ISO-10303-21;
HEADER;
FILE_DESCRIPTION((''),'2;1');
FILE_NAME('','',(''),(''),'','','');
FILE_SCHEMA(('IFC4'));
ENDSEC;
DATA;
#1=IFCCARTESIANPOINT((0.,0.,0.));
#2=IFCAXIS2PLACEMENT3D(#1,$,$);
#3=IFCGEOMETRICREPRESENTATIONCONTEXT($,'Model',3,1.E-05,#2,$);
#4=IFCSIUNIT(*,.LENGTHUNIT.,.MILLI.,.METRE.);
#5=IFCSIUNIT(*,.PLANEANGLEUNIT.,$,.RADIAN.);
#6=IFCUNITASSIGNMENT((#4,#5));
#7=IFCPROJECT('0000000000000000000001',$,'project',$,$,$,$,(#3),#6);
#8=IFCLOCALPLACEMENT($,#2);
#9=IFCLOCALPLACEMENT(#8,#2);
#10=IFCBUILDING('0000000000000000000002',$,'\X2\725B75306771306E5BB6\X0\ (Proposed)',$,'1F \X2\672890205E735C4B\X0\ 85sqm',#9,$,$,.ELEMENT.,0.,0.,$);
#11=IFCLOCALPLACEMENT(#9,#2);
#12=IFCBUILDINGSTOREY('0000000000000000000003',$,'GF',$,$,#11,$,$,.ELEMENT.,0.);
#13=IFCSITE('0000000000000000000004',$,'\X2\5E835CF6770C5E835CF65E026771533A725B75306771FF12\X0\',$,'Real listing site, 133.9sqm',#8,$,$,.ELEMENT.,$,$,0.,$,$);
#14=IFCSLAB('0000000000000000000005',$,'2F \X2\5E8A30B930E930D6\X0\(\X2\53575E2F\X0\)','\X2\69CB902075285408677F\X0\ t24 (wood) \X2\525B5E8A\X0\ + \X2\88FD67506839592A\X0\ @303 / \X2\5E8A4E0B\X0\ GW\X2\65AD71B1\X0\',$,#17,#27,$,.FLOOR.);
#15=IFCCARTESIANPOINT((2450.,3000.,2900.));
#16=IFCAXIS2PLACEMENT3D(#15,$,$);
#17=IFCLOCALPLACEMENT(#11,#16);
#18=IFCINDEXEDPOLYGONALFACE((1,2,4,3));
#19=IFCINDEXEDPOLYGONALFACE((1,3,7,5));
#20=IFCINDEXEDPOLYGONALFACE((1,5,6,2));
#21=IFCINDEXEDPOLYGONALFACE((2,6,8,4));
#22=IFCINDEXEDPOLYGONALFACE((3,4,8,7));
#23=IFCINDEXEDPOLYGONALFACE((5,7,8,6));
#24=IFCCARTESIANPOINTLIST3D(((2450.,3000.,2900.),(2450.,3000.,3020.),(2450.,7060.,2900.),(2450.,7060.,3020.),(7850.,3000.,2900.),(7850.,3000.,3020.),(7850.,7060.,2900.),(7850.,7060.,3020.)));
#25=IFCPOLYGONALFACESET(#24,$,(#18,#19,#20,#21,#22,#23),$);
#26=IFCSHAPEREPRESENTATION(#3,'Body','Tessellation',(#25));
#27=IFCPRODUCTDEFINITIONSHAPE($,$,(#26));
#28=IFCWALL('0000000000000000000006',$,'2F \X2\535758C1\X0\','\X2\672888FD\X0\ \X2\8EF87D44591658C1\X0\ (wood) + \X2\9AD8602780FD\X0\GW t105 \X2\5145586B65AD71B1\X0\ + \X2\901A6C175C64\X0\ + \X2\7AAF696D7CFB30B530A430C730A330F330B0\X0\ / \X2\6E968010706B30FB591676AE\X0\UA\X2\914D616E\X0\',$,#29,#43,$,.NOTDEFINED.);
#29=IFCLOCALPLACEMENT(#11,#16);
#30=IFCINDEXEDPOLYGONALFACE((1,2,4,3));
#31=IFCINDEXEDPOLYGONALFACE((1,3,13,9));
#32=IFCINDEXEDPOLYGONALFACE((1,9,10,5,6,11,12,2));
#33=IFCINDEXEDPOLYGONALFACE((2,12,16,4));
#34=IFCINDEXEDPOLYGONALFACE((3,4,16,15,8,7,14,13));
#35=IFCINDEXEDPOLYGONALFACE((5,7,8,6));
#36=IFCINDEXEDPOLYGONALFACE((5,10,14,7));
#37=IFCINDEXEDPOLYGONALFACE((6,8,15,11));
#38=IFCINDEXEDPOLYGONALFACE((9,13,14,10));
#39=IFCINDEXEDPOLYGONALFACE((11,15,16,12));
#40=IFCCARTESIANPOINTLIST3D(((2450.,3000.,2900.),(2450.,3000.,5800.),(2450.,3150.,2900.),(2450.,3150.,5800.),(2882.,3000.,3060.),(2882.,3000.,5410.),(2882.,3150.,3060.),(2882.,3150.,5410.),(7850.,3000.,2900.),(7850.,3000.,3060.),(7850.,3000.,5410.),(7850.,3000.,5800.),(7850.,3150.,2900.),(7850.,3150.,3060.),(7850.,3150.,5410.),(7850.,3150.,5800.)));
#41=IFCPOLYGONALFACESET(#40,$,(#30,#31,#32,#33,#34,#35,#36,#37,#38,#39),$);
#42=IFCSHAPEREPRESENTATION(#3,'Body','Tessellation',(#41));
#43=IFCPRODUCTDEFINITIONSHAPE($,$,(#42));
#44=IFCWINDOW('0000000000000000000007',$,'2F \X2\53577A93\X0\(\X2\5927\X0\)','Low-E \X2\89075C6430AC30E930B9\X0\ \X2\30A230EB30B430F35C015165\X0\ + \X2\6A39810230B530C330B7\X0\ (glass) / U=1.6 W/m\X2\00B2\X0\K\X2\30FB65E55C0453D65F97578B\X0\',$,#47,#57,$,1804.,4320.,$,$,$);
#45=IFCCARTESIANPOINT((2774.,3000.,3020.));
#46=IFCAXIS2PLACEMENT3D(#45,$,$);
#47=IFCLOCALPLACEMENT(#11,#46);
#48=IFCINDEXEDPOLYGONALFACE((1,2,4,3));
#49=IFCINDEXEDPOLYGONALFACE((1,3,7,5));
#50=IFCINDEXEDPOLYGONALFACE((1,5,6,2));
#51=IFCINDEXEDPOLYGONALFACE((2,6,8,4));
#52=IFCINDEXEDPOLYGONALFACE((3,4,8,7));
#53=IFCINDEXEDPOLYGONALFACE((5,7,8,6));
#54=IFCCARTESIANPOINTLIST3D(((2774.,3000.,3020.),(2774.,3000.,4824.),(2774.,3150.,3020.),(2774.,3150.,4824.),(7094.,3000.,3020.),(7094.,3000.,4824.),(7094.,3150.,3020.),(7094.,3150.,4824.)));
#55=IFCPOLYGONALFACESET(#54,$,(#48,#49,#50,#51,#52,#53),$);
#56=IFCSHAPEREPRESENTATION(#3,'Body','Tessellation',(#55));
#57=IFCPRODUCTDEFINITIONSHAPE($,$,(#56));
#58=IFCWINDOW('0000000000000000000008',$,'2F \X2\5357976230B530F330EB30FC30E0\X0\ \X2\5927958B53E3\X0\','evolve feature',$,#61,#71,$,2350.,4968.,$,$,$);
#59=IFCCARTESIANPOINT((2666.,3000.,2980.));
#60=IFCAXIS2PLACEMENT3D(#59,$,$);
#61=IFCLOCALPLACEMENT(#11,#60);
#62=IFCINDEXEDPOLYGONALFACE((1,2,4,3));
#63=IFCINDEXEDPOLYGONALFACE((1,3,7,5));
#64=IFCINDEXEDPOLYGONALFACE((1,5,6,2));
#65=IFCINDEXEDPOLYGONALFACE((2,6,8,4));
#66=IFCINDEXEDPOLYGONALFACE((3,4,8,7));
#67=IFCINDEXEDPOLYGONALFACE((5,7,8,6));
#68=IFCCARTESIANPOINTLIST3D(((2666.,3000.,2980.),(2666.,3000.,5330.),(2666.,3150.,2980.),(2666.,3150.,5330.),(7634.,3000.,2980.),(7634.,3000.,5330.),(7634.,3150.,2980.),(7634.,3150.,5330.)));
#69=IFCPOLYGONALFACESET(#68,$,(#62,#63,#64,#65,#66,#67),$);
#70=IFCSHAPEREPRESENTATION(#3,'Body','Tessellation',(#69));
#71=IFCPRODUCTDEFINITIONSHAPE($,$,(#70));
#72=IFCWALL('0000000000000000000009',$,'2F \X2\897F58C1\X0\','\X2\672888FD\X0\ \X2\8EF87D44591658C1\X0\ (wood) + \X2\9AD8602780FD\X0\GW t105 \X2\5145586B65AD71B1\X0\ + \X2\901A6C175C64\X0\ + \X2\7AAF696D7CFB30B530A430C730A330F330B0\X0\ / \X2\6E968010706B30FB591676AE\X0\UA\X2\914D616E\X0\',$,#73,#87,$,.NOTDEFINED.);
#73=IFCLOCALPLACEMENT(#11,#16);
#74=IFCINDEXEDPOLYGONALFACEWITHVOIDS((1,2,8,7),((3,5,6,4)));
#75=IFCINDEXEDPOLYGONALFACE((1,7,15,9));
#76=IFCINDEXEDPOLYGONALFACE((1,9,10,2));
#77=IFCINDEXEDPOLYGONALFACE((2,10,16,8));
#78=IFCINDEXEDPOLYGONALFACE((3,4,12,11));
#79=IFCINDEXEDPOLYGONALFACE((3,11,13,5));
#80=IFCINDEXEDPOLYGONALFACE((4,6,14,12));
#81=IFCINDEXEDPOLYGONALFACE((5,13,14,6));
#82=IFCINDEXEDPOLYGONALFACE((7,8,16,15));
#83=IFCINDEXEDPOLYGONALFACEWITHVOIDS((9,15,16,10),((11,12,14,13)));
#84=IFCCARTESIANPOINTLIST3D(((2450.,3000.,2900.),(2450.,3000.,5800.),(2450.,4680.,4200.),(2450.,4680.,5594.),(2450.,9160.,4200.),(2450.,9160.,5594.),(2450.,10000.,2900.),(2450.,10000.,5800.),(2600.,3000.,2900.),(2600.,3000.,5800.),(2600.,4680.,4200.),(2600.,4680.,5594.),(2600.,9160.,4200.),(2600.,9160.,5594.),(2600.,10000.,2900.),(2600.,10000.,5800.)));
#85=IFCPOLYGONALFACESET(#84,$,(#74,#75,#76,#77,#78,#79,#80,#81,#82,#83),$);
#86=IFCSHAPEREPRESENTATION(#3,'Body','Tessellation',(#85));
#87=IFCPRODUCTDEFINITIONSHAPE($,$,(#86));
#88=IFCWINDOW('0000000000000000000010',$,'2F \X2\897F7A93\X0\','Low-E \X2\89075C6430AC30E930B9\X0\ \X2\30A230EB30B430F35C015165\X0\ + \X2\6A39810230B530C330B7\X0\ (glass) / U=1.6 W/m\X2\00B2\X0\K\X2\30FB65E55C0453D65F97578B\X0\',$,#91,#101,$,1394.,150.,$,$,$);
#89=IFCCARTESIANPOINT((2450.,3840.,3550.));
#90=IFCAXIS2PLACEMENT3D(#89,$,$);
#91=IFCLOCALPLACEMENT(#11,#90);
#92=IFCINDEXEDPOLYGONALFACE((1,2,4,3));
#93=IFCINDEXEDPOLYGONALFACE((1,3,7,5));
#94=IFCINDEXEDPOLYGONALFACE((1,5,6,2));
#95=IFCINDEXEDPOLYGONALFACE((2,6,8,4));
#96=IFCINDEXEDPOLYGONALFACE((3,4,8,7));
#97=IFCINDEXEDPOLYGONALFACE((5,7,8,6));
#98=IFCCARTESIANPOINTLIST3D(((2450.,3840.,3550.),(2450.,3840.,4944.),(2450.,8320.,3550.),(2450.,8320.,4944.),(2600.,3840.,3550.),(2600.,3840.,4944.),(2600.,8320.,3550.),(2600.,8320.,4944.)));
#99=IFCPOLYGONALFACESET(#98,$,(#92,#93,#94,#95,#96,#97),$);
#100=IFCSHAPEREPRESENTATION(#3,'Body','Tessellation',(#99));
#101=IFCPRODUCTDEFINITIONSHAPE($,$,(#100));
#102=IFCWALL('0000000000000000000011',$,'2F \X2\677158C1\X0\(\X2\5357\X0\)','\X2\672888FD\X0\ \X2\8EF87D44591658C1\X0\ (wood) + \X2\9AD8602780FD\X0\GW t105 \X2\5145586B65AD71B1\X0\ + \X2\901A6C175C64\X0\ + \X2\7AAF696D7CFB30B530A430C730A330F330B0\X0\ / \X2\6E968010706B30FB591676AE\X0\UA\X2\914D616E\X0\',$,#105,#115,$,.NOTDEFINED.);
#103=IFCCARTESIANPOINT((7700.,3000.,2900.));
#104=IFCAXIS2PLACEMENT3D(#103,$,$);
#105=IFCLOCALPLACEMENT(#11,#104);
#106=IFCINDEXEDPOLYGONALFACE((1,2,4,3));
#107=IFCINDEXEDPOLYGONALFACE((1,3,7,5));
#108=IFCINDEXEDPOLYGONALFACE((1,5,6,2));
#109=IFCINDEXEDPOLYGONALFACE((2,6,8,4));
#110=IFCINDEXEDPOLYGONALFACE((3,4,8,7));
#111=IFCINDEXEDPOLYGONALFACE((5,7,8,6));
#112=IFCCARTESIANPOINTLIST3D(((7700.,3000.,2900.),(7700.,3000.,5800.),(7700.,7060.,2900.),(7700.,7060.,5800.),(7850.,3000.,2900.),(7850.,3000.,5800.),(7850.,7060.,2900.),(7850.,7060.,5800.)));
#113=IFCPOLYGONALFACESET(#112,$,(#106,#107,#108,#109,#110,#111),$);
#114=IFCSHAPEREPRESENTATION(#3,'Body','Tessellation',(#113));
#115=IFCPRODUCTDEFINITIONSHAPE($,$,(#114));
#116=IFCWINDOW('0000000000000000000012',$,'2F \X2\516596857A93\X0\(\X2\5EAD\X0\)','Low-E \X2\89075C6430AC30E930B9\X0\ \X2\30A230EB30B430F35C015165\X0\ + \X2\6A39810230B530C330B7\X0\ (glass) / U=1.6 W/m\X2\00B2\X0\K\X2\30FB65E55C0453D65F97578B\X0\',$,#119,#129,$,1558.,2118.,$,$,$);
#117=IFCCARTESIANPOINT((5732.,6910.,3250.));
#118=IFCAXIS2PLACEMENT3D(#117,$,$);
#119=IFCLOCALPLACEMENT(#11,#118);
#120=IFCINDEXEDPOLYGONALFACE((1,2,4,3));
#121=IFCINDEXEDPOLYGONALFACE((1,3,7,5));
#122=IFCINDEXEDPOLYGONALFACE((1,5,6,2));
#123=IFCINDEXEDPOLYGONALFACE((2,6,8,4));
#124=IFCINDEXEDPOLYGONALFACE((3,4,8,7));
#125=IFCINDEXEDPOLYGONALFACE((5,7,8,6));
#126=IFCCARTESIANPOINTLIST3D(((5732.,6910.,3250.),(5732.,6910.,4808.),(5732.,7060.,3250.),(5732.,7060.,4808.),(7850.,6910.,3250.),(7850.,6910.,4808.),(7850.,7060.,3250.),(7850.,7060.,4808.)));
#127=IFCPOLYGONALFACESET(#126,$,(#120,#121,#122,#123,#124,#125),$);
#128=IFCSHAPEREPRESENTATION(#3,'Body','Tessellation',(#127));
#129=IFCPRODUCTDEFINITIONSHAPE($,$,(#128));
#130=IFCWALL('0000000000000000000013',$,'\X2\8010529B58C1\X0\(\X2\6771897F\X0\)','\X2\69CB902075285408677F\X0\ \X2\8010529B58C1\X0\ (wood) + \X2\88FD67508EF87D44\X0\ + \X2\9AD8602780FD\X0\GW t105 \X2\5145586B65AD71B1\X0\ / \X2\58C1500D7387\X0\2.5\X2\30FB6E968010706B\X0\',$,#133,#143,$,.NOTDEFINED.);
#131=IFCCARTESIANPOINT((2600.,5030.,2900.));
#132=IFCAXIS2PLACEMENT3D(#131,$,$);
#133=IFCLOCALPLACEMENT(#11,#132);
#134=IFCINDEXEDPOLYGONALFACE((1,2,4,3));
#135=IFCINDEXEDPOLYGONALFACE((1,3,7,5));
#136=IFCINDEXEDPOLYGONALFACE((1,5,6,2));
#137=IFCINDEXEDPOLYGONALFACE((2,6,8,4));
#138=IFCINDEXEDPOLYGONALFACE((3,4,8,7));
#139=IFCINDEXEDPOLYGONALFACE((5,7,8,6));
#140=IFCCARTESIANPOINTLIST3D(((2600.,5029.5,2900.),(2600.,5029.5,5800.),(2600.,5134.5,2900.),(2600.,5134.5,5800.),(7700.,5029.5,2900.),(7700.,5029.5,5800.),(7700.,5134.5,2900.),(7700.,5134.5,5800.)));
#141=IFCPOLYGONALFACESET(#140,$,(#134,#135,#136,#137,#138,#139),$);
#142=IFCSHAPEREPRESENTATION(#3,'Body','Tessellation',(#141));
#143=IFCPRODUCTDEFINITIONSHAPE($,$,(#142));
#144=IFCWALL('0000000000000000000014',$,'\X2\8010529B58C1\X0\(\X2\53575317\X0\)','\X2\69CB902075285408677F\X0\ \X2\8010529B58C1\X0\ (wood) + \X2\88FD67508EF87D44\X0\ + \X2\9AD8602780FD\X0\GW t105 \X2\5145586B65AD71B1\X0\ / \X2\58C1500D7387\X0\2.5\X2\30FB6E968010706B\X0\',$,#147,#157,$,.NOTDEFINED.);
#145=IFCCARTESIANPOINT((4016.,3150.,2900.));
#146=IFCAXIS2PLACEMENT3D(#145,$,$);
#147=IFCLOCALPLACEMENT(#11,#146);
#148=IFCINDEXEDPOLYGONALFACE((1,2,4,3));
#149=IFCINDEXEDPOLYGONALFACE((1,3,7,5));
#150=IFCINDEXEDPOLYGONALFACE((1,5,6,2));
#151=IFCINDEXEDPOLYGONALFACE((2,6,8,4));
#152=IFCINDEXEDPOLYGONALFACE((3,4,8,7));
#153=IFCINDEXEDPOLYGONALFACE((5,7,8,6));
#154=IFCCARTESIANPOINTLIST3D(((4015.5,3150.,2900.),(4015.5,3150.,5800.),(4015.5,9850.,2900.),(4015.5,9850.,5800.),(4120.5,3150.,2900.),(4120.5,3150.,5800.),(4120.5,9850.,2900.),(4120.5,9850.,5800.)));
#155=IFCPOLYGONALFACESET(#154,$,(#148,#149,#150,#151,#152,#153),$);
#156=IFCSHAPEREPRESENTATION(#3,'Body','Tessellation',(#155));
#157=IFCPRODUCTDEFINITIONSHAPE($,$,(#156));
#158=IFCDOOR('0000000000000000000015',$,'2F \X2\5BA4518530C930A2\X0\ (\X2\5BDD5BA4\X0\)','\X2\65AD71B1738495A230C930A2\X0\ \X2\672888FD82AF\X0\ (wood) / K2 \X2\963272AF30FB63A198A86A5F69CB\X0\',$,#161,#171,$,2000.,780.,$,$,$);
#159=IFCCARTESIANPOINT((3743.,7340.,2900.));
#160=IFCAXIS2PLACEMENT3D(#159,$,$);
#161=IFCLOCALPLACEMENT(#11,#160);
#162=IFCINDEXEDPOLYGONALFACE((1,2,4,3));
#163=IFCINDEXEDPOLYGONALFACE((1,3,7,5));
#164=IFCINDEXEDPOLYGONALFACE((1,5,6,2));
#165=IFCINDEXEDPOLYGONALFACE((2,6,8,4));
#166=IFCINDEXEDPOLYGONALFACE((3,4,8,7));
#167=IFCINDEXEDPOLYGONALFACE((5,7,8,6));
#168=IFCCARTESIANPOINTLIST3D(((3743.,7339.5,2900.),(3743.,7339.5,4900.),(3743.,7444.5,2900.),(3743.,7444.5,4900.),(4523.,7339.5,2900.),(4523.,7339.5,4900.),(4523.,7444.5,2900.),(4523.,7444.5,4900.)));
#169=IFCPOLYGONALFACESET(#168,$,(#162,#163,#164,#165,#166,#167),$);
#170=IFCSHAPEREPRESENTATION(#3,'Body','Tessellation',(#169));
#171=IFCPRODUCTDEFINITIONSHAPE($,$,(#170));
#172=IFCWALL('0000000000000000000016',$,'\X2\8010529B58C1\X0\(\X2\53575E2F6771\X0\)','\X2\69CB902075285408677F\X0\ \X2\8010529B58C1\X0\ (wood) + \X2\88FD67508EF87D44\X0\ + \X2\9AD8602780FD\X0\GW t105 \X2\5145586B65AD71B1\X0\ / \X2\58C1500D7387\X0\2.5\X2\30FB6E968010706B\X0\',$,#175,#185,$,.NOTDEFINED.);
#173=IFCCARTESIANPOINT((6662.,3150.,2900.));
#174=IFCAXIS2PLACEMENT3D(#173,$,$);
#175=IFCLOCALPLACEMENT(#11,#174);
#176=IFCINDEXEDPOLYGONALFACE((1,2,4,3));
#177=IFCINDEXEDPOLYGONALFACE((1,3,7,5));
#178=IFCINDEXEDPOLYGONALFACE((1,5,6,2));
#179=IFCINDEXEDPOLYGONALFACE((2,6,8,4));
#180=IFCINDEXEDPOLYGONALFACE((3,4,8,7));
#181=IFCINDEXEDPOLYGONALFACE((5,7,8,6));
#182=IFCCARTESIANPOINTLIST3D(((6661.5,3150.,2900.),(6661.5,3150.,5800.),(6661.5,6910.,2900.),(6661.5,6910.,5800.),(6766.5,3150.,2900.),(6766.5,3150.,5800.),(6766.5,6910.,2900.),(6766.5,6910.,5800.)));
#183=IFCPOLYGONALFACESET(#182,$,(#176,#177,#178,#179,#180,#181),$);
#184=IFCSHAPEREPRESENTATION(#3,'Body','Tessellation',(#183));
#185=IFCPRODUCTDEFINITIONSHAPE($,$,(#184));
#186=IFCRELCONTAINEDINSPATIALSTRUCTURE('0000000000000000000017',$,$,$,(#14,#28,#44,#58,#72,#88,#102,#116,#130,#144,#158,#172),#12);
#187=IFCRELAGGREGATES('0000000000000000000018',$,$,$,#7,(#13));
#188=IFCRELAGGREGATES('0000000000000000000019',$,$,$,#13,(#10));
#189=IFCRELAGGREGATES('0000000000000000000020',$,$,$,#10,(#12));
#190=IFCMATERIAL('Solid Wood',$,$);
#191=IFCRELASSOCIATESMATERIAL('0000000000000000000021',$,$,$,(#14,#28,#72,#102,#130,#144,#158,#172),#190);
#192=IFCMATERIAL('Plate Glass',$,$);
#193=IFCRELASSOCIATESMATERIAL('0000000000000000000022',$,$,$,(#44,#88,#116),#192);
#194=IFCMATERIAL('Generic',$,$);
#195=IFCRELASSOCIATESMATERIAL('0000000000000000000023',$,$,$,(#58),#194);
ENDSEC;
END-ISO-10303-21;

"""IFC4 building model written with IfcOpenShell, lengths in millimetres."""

from ifc_helpers import new_model, si_unit, frame, frame_2d, origin, place, context, project, spatial, rectangle, extrude, material, element, fill, save


model = new_model("IFC4")

# Units and contexts
model_context = context("Model", 3, precision=1e-05, world=origin())
ifc_project = project(units=[si_unit("LENGTHUNIT", "METRE", prefix="MILLI"), si_unit("PLANEANGLEUNIT", "RADIAN")], contexts=[model_context])

# Site, building, storey
site_placement = place(None, origin())
site = spatial("IfcSite", under=ifc_project, at=site_placement, Name="広島県広島市東区牛田東２", ObjectType="Real listing site, 133.9sqm", CompositionType="ELEMENT", RefElevation=0.0)
building_placement = place(site_placement, origin())
building = spatial("IfcBuilding", under=site, at=building_placement, Name="牛田東の家 (Proposed)", ObjectType="1F 木造平屋 85sqm", CompositionType="ELEMENT", ElevationOfRefHeight=0.0, ElevationOfTerrain=0.0)
storey_placement = place(building_placement, origin())
storey = spatial("IfcBuildingStorey", under=building, at=storey_placement, Name="GF", CompositionType="ELEMENT", Elevation=0.0)

# Slab
ifc_material_1 = material(Name="Solid Wood")
slab_placement = place(storey_placement, frame((2450.0, 3000.0, 2900.0)))
element("IfcSlab", 1, at=slab_placement, inside=storey, material=ifc_material_1, Name="2F 床スラブ(南帯)", Description="構造用合板 t24 (wood) 剛床 + 製材根太 @303 / 床下 GW断熱", PredefinedType="FLOOR", context=model_context, shape_type="SweptSolid", body=[
    extrude(rectangle(XDim=5400.0, YDim=4060.0, at=frame_2d((2700.0, 2030.0))), frame((2450.0, 3000.0, 2900.0)), (0.0, 0.0, 1.0), 120.0),
])

# Wall, openings, windows
wall_1_placement = place(storey_placement, frame((2450.0, 3000.0, 2900.0)))
wall_1 = element("IfcWall", 2, at=wall_1_placement, inside=storey, material=ifc_material_1, Name="2F 南壁", Description="木製 軸組外壁 (wood) + 高性能GW t105 充填断熱 + 通気層 + 窯業系サイディング / 準耐火・外皮UA配慮", PredefinedType="NOTDEFINED", context=model_context, shape_type="SweptSolid", body=[
    extrude(rectangle(XDim=5400.0, YDim=150.0, at=frame_2d((2700.0, 75.0))), frame((2450.0, 3000.0, 2900.0)), (0.0, 0.0, 1.0), 2900.0),
])
opening_1_placement = place(storey_placement, frame((2774.0, 3000.0, 3020.0)))
opening_1 = element("IfcOpeningElement", 3, at=opening_1_placement, cuts=wall_1, PredefinedType="NOTDEFINED", context=model_context, shape_type="SweptSolid", body=[
    extrude(rectangle(XDim=4320.0, YDim=150.0, at=frame_2d((2160.0, 75.0))), frame((2774.0, 3000.0, 3020.0)), (0.0, 0.0, 1.0), 1804.0),
])
opening_2_placement = place(storey_placement, frame((2666.0, 3000.0, 2980.0)))
opening_2 = element("IfcOpeningElement", 4, at=opening_2_placement, cuts=wall_1, PredefinedType="NOTDEFINED", context=model_context, shape_type="SweptSolid", body=[
    extrude(rectangle(XDim=4968.0, YDim=150.0, at=frame_2d((2484.0, 75.0))), frame((2666.0, 3000.0, 2980.0)), (0.0, 0.0, 1.0), 2350.0),
])
ifc_material_2 = material(Name="Plate Glass")
window_1_placement = place(storey_placement, frame((2774.0, 3000.0, 3020.0)))
window_1 = element("IfcWindow", 5, at=window_1_placement, inside=storey, material=ifc_material_2, Name="2F 南窓(大)", Description="Low-E 複層ガラス アルゴン封入 + 樹脂サッシ (glass) / U=1.6 W/m²K・日射取得型", OverallHeight=1804.0, OverallWidth=4320.0, context=model_context, shape_type="SweptSolid", body=[
    extrude(rectangle(XDim=4320.0, YDim=150.0, at=frame_2d((2160.0, 75.0))), frame((2774.0, 3000.0, 3020.0)), (0.0, 0.0, 1.0), 1804.0),
])
fill(opening_1, window_1)
ifc_material_3 = material(Name="Generic")
window_2_placement = place(storey_placement, frame((2666.0, 3000.0, 2980.0)))
window_2 = element("IfcWindow", 6, at=window_2_placement, inside=storey, material=ifc_material_3, Name="2F 南面サンルーム 大開口", Description="evolve feature", OverallHeight=2350.0, OverallWidth=4968.0, context=model_context, shape_type="SweptSolid", body=[
    extrude(rectangle(XDim=4968.0, YDim=150.0, at=frame_2d((2484.0, 75.0))), frame((2666.0, 3000.0, 2980.0)), (0.0, 0.0, 1.0), 2350.0),
])
fill(opening_2, window_2)

# Walls, openings, windows
wall_2_placement = place(storey_placement, frame((2450.0, 3000.0, 2900.0)))
wall_2 = element("IfcWall", 7, at=wall_2_placement, inside=storey, material=ifc_material_1, Name="2F 西壁", Description="木製 軸組外壁 (wood) + 高性能GW t105 充填断熱 + 通気層 + 窯業系サイディング / 準耐火・外皮UA配慮", PredefinedType="NOTDEFINED", context=model_context, shape_type="SweptSolid", body=[
    extrude(rectangle(XDim=150.0, YDim=7000.0, at=frame_2d((75.0, 3500.0))), frame((2450.0, 3000.0, 2900.0)), (0.0, 0.0, 1.0), 2900.0),
])
opening_3_placement = place(storey_placement, frame((2450.0, 3840.0, 3550.0)))
opening_3 = element("IfcOpeningElement", 8, at=opening_3_placement, cuts=wall_2, PredefinedType="NOTDEFINED", context=model_context, shape_type="SweptSolid", body=[
    extrude(rectangle(XDim=150.0, YDim=4480.0, at=frame_2d((75.0, 2240.0))), frame((2450.0, 3840.0, 3550.0)), (0.0, 0.0, 1.0), 1394.0),
])
window_3_placement = place(storey_placement, frame((2450.0, 3840.0, 3550.0)))
window_3 = element("IfcWindow", 9, at=window_3_placement, inside=storey, material=ifc_material_2, Name="2F 西窓", Description="Low-E 複層ガラス アルゴン封入 + 樹脂サッシ (glass) / U=1.6 W/m²K・日射取得型", OverallHeight=1394.0, OverallWidth=150.0, context=model_context, shape_type="SweptSolid", body=[
    extrude(rectangle(XDim=150.0, YDim=4480.0, at=frame_2d((75.0, 2240.0))), frame((2450.0, 3840.0, 3550.0)), (0.0, 0.0, 1.0), 1394.0),
])
fill(opening_3, window_3)
wall_3_placement = place(storey_placement, frame((7700.0, 3000.0, 2900.0)))
wall_3 = element("IfcWall", 10, at=wall_3_placement, inside=storey, material=ifc_material_1, Name="2F 東壁(南)", Description="木製 軸組外壁 (wood) + 高性能GW t105 充填断熱 + 通気層 + 窯業系サイディング / 準耐火・外皮UA配慮", PredefinedType="NOTDEFINED", context=model_context, shape_type="SweptSolid", body=[
    extrude(rectangle(XDim=150.0, YDim=4060.0, at=frame_2d((75.0, 2030.0))), frame((7700.0, 3000.0, 2900.0)), (0.0, 0.0, 1.0), 2900.0),
])
opening_4_placement = place(storey_placement, frame((5732.0, 6910.0, 3250.0)))
opening_4 = element("IfcOpeningElement", 11, at=opening_4_placement, cuts=wall_3, PredefinedType="NOTDEFINED", context=model_context, shape_type="SweptSolid", body=[
    extrude(rectangle(XDim=2118.0, YDim=150.0, at=frame_2d((1059.0, 75.0))), frame((5732.0, 6910.0, 3250.0)), (0.0, 0.0, 1.0), 1558.0),
])
window_4_placement = place(storey_placement, frame((5732.0, 6910.0, 3250.0)))
window_4 = element("IfcWindow", 12, at=window_4_placement, inside=storey, material=ifc_material_2, Name="2F 入隅窓(庭)", Description="Low-E 複層ガラス アルゴン封入 + 樹脂サッシ (glass) / U=1.6 W/m²K・日射取得型", OverallHeight=1558.0, OverallWidth=2118.0, context=model_context, shape_type="SweptSolid", body=[
    extrude(rectangle(XDim=2118.0, YDim=150.0, at=frame_2d((1059.0, 75.0))), frame((5732.0, 6910.0, 3250.0)), (0.0, 0.0, 1.0), 1558.0),
])
fill(opening_4, window_4)

# Wall
wall_4_placement = place(storey_placement, frame((2600.0, 5030.0, 2900.0)))
element("IfcWall", 13, at=wall_4_placement, inside=storey, material=ifc_material_1, Name="耐力壁(東西)", Description="構造用合板 耐力壁 (wood) + 製材軸組 + 高性能GW t105 充填断熱 / 壁倍率2.5・準耐火", PredefinedType="NOTDEFINED", context=model_context, shape_type="SweptSolid", body=[
    extrude(rectangle(XDim=5100.0, YDim=105.0, at=frame_2d((2550.0, 52.0))), frame((2600.0, 5030.0, 2900.0)), (0.0, 0.0, 1.0), 2900.0),
])

# Wall, opening, door
wall_5_placement = place(storey_placement, frame((4016.0, 3150.0, 2900.0)))
wall_5 = element("IfcWall", 14, at=wall_5_placement, inside=storey, material=ifc_material_1, Name="耐力壁(南北)", Description="構造用合板 耐力壁 (wood) + 製材軸組 + 高性能GW t105 充填断熱 / 壁倍率2.5・準耐火", PredefinedType="NOTDEFINED", context=model_context, shape_type="SweptSolid", body=[
    extrude(rectangle(XDim=105.0, YDim=6700.0, at=frame_2d((52.0, 3350.0))), frame((4016.0, 3150.0, 2900.0)), (0.0, 0.0, 1.0), 2900.0),
])
opening_5_placement = place(storey_placement, frame((3743.0, 7340.0, 2900.0)))
opening_5 = element("IfcOpeningElement", 15, at=opening_5_placement, cuts=wall_5, PredefinedType="NOTDEFINED", context=model_context, shape_type="SweptSolid", body=[
    extrude(rectangle(XDim=780.0, YDim=105.0, at=frame_2d((390.0, 52.0))), frame((3743.0, 7340.0, 2900.0)), (0.0, 0.0, 1.0), 2000.0),
])
door_placement = place(storey_placement, frame((3743.0, 7340.0, 2900.0)))
door = element("IfcDoor", 16, at=door_placement, inside=storey, material=ifc_material_1, Name="2F 室内ドア (寝室)", Description="断熱玄関ドア 木製芯 (wood) / K2 防犯・採風機構", OverallHeight=2000.0, OverallWidth=780.0, context=model_context, shape_type="SweptSolid", body=[
    extrude(rectangle(XDim=780.0, YDim=105.0, at=frame_2d((390.0, 52.0))), frame((3743.0, 7340.0, 2900.0)), (0.0, 0.0, 1.0), 2000.0),
])
fill(opening_5, door)

# Wall
wall_6_placement = place(storey_placement, frame((6662.0, 3150.0, 2900.0)))
element("IfcWall", 17, at=wall_6_placement, inside=storey, material=ifc_material_1, Name="耐力壁(南帯東)", Description="構造用合板 耐力壁 (wood) + 製材軸組 + 高性能GW t105 充填断熱 / 壁倍率2.5・準耐火", PredefinedType="NOTDEFINED", context=model_context, shape_type="SweptSolid", body=[
    extrude(rectangle(XDim=105.0, YDim=3760.0, at=frame_2d((52.0, 1880.0))), frame((6662.0, 3150.0, 2900.0)), (0.0, 0.0, 1.0), 2900.0),
])

save(model, "model.ifc")
